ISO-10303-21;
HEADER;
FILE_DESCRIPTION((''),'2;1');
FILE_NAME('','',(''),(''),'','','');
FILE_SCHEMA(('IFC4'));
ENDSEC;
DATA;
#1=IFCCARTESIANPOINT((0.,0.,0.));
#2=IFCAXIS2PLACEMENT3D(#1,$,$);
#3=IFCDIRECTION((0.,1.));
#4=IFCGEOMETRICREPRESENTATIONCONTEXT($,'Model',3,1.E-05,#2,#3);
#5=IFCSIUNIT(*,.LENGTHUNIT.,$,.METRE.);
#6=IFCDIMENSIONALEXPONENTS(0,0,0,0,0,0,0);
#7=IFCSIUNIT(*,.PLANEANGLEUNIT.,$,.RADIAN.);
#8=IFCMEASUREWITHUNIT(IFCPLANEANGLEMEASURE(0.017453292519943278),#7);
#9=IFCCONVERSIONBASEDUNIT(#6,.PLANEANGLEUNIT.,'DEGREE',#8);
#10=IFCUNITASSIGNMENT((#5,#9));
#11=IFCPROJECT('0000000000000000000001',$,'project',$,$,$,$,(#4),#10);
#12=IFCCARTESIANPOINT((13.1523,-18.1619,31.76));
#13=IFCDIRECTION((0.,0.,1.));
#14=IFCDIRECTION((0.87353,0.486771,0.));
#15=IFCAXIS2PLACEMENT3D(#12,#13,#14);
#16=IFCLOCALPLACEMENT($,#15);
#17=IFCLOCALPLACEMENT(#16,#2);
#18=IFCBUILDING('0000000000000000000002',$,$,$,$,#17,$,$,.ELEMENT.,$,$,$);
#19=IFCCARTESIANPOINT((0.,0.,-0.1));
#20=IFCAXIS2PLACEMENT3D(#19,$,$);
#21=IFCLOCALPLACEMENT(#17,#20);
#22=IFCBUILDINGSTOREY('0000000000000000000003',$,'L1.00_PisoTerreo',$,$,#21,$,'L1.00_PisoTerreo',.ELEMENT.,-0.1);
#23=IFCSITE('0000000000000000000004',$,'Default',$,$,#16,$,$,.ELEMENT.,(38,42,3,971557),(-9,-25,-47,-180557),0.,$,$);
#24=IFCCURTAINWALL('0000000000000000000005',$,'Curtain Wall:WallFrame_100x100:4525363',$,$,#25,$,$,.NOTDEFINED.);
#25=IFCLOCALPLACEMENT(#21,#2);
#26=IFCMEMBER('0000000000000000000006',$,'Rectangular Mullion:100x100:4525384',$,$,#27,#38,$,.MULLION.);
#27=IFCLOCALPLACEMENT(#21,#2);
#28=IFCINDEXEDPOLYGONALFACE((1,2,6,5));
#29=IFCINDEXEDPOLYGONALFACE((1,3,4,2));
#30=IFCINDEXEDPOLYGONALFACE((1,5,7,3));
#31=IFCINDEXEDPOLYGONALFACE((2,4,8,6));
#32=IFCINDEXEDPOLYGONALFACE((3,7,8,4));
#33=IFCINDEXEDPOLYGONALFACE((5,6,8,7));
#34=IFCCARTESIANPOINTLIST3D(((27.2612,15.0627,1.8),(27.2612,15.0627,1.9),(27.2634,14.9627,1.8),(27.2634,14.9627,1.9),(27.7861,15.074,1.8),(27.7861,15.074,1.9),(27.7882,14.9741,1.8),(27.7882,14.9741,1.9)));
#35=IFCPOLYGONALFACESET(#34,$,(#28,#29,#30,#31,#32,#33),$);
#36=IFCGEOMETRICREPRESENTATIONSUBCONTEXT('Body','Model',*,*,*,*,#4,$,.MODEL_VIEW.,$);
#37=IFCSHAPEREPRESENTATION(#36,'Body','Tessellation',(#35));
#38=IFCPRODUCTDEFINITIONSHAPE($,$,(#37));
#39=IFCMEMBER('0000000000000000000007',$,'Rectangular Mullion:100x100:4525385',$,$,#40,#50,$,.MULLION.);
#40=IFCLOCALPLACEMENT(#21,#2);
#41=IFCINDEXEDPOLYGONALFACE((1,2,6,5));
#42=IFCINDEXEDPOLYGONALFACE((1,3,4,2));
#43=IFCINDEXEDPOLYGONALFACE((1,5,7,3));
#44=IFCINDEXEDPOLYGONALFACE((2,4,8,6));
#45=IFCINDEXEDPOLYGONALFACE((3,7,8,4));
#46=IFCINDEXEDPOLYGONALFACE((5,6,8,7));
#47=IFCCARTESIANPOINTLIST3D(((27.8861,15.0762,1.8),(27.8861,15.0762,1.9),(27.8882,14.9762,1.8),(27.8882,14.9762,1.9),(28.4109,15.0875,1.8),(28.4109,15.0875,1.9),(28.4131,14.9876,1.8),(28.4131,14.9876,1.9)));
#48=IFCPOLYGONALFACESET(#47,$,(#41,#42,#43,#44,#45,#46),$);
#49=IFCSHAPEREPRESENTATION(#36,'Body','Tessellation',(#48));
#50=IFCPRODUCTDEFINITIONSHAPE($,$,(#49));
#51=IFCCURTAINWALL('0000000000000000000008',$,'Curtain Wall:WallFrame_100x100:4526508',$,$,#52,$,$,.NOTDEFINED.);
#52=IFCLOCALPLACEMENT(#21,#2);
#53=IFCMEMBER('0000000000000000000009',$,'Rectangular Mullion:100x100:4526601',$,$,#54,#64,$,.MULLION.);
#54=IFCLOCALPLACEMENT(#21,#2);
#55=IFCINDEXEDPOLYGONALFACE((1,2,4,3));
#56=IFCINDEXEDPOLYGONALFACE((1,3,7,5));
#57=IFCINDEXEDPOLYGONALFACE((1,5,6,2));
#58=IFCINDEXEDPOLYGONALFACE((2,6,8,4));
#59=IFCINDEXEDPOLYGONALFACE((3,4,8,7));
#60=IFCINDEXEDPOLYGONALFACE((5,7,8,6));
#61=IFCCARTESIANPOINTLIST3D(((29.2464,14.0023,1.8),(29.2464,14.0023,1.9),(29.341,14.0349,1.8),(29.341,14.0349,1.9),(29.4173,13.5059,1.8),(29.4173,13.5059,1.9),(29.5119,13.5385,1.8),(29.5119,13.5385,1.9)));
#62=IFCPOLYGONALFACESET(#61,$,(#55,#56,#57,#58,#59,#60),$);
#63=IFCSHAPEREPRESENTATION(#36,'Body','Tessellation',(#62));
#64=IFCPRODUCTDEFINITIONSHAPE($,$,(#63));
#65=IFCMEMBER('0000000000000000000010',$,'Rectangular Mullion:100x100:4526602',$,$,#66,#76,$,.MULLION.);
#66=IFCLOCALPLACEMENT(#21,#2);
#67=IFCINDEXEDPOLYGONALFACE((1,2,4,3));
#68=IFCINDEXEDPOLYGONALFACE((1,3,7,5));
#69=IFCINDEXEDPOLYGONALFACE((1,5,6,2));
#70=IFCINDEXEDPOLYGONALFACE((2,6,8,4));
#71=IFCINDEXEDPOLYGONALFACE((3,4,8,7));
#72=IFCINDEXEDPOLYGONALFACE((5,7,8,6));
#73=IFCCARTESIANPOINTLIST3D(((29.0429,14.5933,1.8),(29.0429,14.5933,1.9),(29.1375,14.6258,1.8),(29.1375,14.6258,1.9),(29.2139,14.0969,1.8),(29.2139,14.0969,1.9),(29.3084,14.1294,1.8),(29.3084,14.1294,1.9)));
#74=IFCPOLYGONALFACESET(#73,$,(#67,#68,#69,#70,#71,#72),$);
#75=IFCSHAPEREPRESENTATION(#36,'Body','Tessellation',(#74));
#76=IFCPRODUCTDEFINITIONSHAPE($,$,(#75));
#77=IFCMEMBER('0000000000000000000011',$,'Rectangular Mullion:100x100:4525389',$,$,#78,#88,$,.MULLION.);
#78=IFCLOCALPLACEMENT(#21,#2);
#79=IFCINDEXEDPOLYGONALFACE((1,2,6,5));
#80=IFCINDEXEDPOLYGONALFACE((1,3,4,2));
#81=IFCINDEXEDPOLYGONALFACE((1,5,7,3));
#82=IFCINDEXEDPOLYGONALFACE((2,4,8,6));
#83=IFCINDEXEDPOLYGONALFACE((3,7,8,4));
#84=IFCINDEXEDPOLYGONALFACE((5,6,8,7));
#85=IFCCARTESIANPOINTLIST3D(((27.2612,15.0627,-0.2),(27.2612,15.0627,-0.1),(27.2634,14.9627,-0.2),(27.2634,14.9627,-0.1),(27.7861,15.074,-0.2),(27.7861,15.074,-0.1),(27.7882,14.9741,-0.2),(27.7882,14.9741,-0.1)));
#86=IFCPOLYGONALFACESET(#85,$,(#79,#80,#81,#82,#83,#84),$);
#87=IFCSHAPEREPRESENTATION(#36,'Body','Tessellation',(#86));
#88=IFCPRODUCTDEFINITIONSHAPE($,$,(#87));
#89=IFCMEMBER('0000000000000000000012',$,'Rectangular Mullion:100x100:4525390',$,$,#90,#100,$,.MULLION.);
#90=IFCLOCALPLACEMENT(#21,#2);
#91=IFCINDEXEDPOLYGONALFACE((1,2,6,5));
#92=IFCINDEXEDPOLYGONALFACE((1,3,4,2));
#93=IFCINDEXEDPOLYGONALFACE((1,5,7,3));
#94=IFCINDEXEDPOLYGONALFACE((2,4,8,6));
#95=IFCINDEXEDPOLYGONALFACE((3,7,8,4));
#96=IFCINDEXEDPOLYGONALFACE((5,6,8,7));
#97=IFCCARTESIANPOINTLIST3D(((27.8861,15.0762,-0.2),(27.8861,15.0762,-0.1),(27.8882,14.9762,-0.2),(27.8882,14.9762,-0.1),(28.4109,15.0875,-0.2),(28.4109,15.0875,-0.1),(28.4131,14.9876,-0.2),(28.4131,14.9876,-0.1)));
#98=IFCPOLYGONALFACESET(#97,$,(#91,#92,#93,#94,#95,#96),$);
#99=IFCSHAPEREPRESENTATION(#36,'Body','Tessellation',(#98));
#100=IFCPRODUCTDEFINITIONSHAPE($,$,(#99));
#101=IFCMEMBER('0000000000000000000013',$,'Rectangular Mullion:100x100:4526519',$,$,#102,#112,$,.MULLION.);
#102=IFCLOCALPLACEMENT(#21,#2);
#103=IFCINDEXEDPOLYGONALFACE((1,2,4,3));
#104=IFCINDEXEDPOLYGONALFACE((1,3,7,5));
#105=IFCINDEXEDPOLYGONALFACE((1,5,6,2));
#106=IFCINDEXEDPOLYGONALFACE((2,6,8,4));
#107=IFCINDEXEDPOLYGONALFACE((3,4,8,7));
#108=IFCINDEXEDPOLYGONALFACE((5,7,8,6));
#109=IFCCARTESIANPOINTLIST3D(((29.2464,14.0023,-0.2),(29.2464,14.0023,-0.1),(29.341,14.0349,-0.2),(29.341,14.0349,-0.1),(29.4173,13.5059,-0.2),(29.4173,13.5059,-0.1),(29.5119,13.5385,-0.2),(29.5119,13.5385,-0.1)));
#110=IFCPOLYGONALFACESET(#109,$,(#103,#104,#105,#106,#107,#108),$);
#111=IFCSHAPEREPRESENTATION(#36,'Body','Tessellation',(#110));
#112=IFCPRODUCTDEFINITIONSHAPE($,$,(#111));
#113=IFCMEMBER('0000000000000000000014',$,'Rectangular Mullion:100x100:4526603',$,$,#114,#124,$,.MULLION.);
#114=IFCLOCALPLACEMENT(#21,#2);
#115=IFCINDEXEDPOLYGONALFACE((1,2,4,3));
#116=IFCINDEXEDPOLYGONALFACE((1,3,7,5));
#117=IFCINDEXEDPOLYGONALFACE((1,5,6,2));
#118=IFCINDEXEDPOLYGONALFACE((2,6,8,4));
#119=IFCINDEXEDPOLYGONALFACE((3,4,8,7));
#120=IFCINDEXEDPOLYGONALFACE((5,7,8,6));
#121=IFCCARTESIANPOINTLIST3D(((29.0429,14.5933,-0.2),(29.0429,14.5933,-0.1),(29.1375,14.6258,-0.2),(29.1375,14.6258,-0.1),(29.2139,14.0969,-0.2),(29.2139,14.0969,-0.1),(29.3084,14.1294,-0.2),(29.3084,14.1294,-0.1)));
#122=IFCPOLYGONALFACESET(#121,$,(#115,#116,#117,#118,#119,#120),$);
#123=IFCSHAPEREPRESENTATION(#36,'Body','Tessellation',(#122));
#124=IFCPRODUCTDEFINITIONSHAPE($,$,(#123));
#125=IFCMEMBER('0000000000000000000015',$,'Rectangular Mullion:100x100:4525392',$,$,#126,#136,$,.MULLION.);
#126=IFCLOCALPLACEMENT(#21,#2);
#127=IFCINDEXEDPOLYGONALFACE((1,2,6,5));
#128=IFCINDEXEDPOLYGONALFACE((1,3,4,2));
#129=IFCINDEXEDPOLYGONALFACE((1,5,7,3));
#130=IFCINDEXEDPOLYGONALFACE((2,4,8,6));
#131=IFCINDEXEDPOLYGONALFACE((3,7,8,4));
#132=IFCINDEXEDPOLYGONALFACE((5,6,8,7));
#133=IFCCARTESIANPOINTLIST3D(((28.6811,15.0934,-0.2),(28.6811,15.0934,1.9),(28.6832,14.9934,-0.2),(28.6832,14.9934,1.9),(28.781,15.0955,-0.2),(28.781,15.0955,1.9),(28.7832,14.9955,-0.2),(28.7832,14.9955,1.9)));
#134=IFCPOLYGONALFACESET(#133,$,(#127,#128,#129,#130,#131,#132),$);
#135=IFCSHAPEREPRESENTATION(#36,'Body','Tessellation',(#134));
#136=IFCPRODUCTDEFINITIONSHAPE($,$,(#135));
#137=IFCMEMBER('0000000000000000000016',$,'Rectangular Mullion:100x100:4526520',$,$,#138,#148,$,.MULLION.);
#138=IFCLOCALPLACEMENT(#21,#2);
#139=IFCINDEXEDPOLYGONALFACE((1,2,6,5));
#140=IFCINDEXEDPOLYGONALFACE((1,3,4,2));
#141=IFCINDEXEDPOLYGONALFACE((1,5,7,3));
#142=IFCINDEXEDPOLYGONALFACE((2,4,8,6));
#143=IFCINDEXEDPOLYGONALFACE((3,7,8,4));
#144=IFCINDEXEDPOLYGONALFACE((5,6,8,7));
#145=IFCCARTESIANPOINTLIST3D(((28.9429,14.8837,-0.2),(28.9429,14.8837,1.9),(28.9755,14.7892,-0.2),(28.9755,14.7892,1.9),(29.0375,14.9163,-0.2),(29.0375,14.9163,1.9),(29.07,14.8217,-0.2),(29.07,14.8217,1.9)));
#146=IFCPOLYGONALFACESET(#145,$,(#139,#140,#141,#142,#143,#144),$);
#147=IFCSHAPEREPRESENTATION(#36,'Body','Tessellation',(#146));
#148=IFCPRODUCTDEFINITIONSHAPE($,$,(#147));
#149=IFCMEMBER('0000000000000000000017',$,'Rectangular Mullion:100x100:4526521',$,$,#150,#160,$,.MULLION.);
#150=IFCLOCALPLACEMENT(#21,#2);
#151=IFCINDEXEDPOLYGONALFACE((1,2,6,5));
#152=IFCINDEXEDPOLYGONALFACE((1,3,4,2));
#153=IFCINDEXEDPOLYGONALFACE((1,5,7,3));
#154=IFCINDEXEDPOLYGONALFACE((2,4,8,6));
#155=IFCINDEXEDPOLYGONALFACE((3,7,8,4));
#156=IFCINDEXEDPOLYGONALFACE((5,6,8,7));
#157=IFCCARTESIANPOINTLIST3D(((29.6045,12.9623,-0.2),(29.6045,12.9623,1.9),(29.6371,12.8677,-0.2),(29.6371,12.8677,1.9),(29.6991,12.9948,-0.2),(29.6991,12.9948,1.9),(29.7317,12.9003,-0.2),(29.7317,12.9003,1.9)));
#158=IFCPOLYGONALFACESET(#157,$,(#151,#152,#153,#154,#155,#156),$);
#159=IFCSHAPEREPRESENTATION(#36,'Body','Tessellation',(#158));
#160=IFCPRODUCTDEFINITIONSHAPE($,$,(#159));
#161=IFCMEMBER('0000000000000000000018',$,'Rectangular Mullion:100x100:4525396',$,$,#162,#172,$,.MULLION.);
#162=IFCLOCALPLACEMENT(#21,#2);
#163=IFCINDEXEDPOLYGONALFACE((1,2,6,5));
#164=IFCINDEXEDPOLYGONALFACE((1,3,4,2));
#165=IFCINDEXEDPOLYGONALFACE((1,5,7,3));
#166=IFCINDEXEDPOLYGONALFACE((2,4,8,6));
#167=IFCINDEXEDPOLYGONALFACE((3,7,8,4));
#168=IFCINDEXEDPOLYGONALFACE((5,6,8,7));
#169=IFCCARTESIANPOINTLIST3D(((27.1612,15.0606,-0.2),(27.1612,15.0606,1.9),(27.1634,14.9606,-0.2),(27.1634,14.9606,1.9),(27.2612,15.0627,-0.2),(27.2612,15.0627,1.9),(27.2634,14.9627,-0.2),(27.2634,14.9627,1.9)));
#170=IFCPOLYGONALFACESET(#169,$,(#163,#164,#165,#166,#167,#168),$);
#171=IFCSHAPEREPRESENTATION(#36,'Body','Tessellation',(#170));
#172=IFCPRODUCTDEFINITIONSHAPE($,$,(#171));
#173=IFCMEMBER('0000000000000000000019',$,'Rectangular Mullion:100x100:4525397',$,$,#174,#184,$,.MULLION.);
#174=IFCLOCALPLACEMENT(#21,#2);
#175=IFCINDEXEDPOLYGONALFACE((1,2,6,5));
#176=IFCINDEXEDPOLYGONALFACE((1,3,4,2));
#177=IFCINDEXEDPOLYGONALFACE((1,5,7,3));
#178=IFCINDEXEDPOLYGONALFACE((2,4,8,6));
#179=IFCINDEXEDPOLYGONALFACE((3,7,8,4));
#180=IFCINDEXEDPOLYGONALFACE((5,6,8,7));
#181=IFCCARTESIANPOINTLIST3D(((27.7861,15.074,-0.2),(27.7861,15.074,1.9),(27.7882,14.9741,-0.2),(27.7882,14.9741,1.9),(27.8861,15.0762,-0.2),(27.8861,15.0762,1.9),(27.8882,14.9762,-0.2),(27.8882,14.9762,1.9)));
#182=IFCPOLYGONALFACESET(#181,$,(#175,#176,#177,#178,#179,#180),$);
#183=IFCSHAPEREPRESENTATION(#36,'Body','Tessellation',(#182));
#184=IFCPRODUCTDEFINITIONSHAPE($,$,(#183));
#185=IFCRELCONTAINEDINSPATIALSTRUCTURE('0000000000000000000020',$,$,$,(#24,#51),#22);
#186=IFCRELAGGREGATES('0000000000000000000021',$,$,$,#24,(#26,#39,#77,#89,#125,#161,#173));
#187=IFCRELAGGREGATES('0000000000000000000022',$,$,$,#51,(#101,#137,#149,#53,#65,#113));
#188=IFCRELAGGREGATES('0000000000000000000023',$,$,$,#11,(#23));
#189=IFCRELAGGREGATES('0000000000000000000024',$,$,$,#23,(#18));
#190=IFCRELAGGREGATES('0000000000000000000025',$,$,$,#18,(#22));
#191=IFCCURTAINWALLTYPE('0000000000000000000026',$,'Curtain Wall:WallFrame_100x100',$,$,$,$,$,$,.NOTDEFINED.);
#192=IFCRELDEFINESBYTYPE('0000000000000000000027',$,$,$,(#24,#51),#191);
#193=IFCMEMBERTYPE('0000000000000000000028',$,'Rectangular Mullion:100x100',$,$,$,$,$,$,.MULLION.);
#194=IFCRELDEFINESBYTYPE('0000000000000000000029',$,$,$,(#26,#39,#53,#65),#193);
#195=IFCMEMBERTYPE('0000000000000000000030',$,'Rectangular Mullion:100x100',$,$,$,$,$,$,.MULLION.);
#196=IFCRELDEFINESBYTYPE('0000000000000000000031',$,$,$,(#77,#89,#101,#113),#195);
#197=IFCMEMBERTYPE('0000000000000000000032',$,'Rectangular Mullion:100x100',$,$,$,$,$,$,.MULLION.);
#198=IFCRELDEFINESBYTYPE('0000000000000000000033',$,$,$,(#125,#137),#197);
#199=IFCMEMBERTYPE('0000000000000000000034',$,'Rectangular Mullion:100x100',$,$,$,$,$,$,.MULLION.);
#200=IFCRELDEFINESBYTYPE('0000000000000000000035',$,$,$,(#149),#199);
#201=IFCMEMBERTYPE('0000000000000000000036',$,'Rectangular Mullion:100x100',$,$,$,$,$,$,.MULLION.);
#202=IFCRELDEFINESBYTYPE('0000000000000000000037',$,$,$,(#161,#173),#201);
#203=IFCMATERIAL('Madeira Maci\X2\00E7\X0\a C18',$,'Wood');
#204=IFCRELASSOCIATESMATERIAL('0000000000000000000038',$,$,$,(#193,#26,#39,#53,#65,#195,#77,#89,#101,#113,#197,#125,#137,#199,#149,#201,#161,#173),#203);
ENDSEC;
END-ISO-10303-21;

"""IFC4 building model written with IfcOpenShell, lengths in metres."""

from ifc_helpers import new_model, entity, si_unit, converted_unit, direction, frame, origin, place, context, subcontext, project, spatial, indexed_curve, outline, extrude, source, transform, mapped, material, type_object, type_shapes, element, aggregate, save


model = new_model("IFC4")

# Units and contexts
model_context = context("Model", 3, precision=1e-05, world=origin(), true_north=direction((0.0, 1.0)))
body_context = subcontext(model_context, "Body", "Model", "MODEL_VIEW")
ifc_project = project(units=[si_unit("LENGTHUNIT", "METRE"), converted_unit("PLANEANGLEUNIT", "DEGREE", entity("IfcPlaneAngleMeasure", 0.017453292519943278), si_unit("PLANEANGLEUNIT", "RADIAN"), dimensions=[0, 0, 0, 0, 0, 0, 0])], contexts=[model_context])

# Site, building, storey
site_placement = place(None, frame((13.1523, -18.1619, 31.76), z_axis=(0.0, 0.0, 1.0), x_axis=(0.87353, 0.486771, 0.0)))
site = spatial("IfcSite", under=ifc_project, at=site_placement, Name="Default", CompositionType="ELEMENT", RefLatitude=(38, 42, 3, 971557), RefLongitude=(-9, -25, -47, -180557), RefElevation=0.0)
building_placement = place(site_placement, origin())
building = spatial("IfcBuilding", under=site, at=building_placement, CompositionType="ELEMENT")
storey_placement = place(building_placement, frame((0.0, 0.0, -0.1)))
storey = spatial("IfcBuildingStorey", under=building, at=storey_placement, Name="L1.00_PisoTerreo", LongName="L1.00_PisoTerreo", CompositionType="ELEMENT", Elevation=-0.1)

# Curtain walls, members
curtain_wall_type = type_object("IfcCurtainWallType", Name="Curtain Wall:WallFrame_100x100", PredefinedType="NOTDEFINED")
curtain_wall_1_placement = place(storey_placement, frame((0.0, 0.0, 0.1)))
curtain_wall_1 = element("IfcCurtainWall", 1, at=curtain_wall_1_placement, inside=storey, type_object=curtain_wall_type, Name="Curtain Wall:WallFrame_100x100:4525363", PredefinedType="NOTDEFINED")
ifc_material_1 = material(Name="Madeira Maciça C18", Category="Wood")
member_type_1 = type_object("IfcMemberType", Name="Rectangular Mullion:100x100", PredefinedType="MULLION", material=ifc_material_1)
shared_shape_1 = source(origin(), body_context, "Body", "SweptSolid", [
    extrude(outline(indexed_curve([(-0.05, -0.05), (0.05, -0.05), (0.05, 0.05), (-0.05, 0.05), (-0.05, -0.05)], self_intersect=False)), frame((-0.05, 0.0, -0.525), z_axis=(0.0, 0.0, 1.0), x_axis=(-1.0, 0.0, 0.0)), (0.0, 0.0, 1.0), 0.525),
])
type_shapes(member_type_1, [shared_shape_1])
member_1_placement = place(curtain_wall_1_placement, frame((27.7872, 15.0241, 1.8), z_axis=(0.999767, 0.021581, 0.0), x_axis=(0.0, 0.0, 1.0)))
member_1 = element("IfcMember", 2, at=member_1_placement, type_object=member_type_1, material=ifc_material_1, Name="Rectangular Mullion:100x100:4525384", PredefinedType="MULLION", context=body_context, shape_type="MappedRepresentation", body=[
    mapped(shared_shape_1, transform((0.0, 0.0, 0.0), scale=1.0)),
])
member_2_placement = place(curtain_wall_1_placement, frame((28.412, 15.0375, 1.8), z_axis=(0.999767, 0.021581, 0.0), x_axis=(0.0, 0.0, 1.0)))
member_2 = element("IfcMember", 3, at=member_2_placement, type_object=member_type_1, material=ifc_material_1, Name="Rectangular Mullion:100x100:4525385", PredefinedType="MULLION", context=body_context, shape_type="MappedRepresentation", body=[
    mapped(shared_shape_1, transform((0.0, 0.0, 0.0), scale=1.0)),
])
curtain_wall_2_placement = place(storey_placement, frame((0.0, 0.0, 0.1)))
curtain_wall_2 = element("IfcCurtainWall", 4, at=curtain_wall_2_placement, inside=storey, type_object=curtain_wall_type, Name="Curtain Wall:WallFrame_100x100:4526508", PredefinedType="NOTDEFINED")
member_3_placement = place(curtain_wall_2_placement, frame((29.2937, 14.0186, 1.8), z_axis=(-0.325568, 0.945519, 0.0), x_axis=(0.0, 0.0, 1.0)))
member_3 = element("IfcMember", 5, at=member_3_placement, type_object=member_type_1, material=ifc_material_1, Name="Rectangular Mullion:100x100:4526601", PredefinedType="MULLION", context=body_context, shape_type="MappedRepresentation", body=[
    mapped(shared_shape_1, transform((0.0, 0.0, 0.0), scale=1.0)),
])
member_4_placement = place(curtain_wall_2_placement, frame((29.0902, 14.6096, 1.8), z_axis=(-0.325568, 0.945519, 0.0), x_axis=(0.0, 0.0, 1.0)))
member_4 = element("IfcMember", 6, at=member_4_placement, type_object=member_type_1, material=ifc_material_1, Name="Rectangular Mullion:100x100:4526602", PredefinedType="MULLION", context=body_context, shape_type="MappedRepresentation", body=[
    mapped(shared_shape_1, transform((0.0, 0.0, 0.0), scale=1.0)),
])

# Members
member_type_2 = type_object("IfcMemberType", Name="Rectangular Mullion:100x100", PredefinedType="MULLION", material=ifc_material_1)
shared_shape_2 = source(origin(), body_context, "Body", "SweptSolid", [
    extrude(outline(indexed_curve([(-0.05, -0.05), (0.05, -0.05), (0.05, 0.05), (-0.05, 0.05), (-0.05, -0.05)], self_intersect=False)), frame((-0.05, 0.0, -0.525), z_axis=(0.0, 0.0, 1.0), x_axis=(0.0, -1.0, 0.0)), (0.0, 0.0, 1.0), 0.525),
])
type_shapes(member_type_2, [shared_shape_2])
member_5_placement = place(curtain_wall_1_placement, frame((27.2623, 15.0127, -0.3), z_axis=(-0.999767, -0.021581, 0.0), x_axis=(0.0, 0.0, -1.0)))
member_5 = element("IfcMember", 7, at=member_5_placement, type_object=member_type_2, material=ifc_material_1, Name="Rectangular Mullion:100x100:4525389", PredefinedType="MULLION", context=body_context, shape_type="MappedRepresentation", body=[
    mapped(shared_shape_2, transform((0.0, 0.0, 0.0), scale=1.0)),
])
member_6_placement = place(curtain_wall_1_placement, frame((27.8871, 15.0262, -0.3), z_axis=(-0.999767, -0.021581, 0.0), x_axis=(0.0, 0.0, -1.0)))
member_6 = element("IfcMember", 8, at=member_6_placement, type_object=member_type_2, material=ifc_material_1, Name="Rectangular Mullion:100x100:4525390", PredefinedType="MULLION", context=body_context, shape_type="MappedRepresentation", body=[
    mapped(shared_shape_2, transform((0.0, 0.0, 0.0), scale=1.0)),
])
member_7_placement = place(curtain_wall_2_placement, frame((29.4646, 13.5222, -0.3), z_axis=(0.325568, -0.945519, 0.0), x_axis=(0.0, 0.0, -1.0)))
member_7 = element("IfcMember", 9, at=member_7_placement, type_object=member_type_2, material=ifc_material_1, Name="Rectangular Mullion:100x100:4526519", PredefinedType="MULLION", context=body_context, shape_type="MappedRepresentation", body=[
    mapped(shared_shape_2, transform((0.0, 0.0, 0.0), scale=1.0)),
])
member_8_placement = place(curtain_wall_2_placement, frame((29.2611, 14.1132, -0.3), z_axis=(0.325568, -0.945519, 0.0), x_axis=(0.0, 0.0, -1.0)))
member_8 = element("IfcMember", 10, at=member_8_placement, type_object=member_type_2, material=ifc_material_1, Name="Rectangular Mullion:100x100:4526603", PredefinedType="MULLION", context=body_context, shape_type="MappedRepresentation", body=[
    mapped(shared_shape_2, transform((0.0, 0.0, 0.0), scale=1.0)),
])
member_type_3 = type_object("IfcMemberType", Name="Rectangular Mullion:100x100", PredefinedType="MULLION", material=ifc_material_1)
shared_shape_3 = source(origin(), body_context, "Body", "SweptSolid", [
    extrude(outline(indexed_curve([(-0.05, -0.05), (0.05, -0.05), (0.05, 0.05), (-0.05, 0.05), (-0.05, -0.05)], self_intersect=False)), frame((-0.05, 0.0, -2.1), z_axis=(0.0, 0.0, 1.0), x_axis=(-1.0, 0.0, 0.0)), (0.0, 0.0, 1.0), 2.1),
])
type_shapes(member_type_3, [shared_shape_3])
member_9_placement = place(curtain_wall_1_placement, frame((28.7821, 15.0455, -0.3), z_axis=(0.0, 0.0, -1.0), x_axis=(0.999767, 0.021581, 0.0)))
member_9 = element("IfcMember", 11, at=member_9_placement, type_object=member_type_3, material=ifc_material_1, Name="Rectangular Mullion:100x100:4525392", PredefinedType="MULLION", context=body_context, shape_type="MappedRepresentation", body=[
    mapped(shared_shape_3, transform((0.0, 0.0, 0.0), scale=1.0)),
])
member_10_placement = place(curtain_wall_2_placement, frame((28.9902, 14.9, -0.3), z_axis=(0.0, 0.0, -1.0), x_axis=(-0.325568, 0.945519, 0.0)))
member_10 = element("IfcMember", 12, at=member_10_placement, type_object=member_type_3, material=ifc_material_1, Name="Rectangular Mullion:100x100:4526520", PredefinedType="MULLION", context=body_context, shape_type="MappedRepresentation", body=[
    mapped(shared_shape_3, transform((0.0, 0.0, 0.0), scale=1.0)),
])
member_type_4 = type_object("IfcMemberType", Name="Rectangular Mullion:100x100", PredefinedType="MULLION", material=ifc_material_1)
shared_shape_4 = source(origin(), body_context, "Body", "SweptSolid", [
    extrude(outline(indexed_curve([(-0.05, -0.05), (0.05, -0.05), (0.05, 0.05), (-0.05, 0.05), (-0.05, -0.05)], self_intersect=False)), frame((-0.05, 0.0, -2.1), z_axis=(0.0, 0.0, 1.0), x_axis=(0.0, -1.0, 0.0)), (0.0, 0.0, 1.0), 2.1),
])
type_shapes(member_type_4, [shared_shape_4])
member_11_placement = place(curtain_wall_2_placement, frame((29.6844, 12.884, 1.8), z_axis=(0.0, 0.0, 1.0), x_axis=(0.325568, -0.945519, 0.0)))
member_11 = element("IfcMember", 13, at=member_11_placement, type_object=member_type_4, material=ifc_material_1, Name="Rectangular Mullion:100x100:4526521", PredefinedType="MULLION", context=body_context, shape_type="MappedRepresentation", body=[
    mapped(shared_shape_4, transform((0.0, 0.0, 0.0), scale=1.0)),
])
member_type_5 = type_object("IfcMemberType", Name="Rectangular Mullion:100x100", PredefinedType="MULLION", material=ifc_material_1)
shared_shape_5 = source(origin(), body_context, "Body", "SweptSolid", [
    extrude(outline(indexed_curve([(-0.05, -0.05), (0.05, -0.05), (0.05, 0.05), (-0.05, 0.05), (-0.05, -0.05)], self_intersect=False)), frame((0.0, 0.0, -2.1), z_axis=(0.0, 0.0, 1.0), x_axis=(-1.0, 0.0, 0.0)), (0.0, 0.0, 1.0), 2.1),
])
type_shapes(member_type_5, [shared_shape_5])
member_12_placement = place(curtain_wall_1_placement, frame((27.2123, 15.0116, -0.3), z_axis=(0.0, 0.0, -1.0), x_axis=(0.999767, 0.021581, 0.0)))
member_12 = element("IfcMember", 14, at=member_12_placement, type_object=member_type_5, material=ifc_material_1, Name="Rectangular Mullion:100x100:4525396", PredefinedType="MULLION", context=body_context, shape_type="MappedRepresentation", body=[
    mapped(shared_shape_5, transform((0.0, 0.0, 0.0), scale=1.0)),
])
member_13_placement = place(curtain_wall_1_placement, frame((27.8371, 15.0251, -0.3), z_axis=(0.0, 0.0, -1.0), x_axis=(0.999767, 0.021581, 0.0)))
member_13 = element("IfcMember", 15, at=member_13_placement, type_object=member_type_5, material=ifc_material_1, Name="Rectangular Mullion:100x100:4525397", PredefinedType="MULLION", context=body_context, shape_type="MappedRepresentation", body=[
    mapped(shared_shape_5, transform((0.0, 0.0, 0.0), scale=1.0)),
])
aggregate(curtain_wall_1, [member_1, member_2, member_5, member_6, member_9, member_12, member_13])
aggregate(curtain_wall_2, [member_7, member_10, member_11, member_3, member_4, member_8])

save(model, "model.ifc")
